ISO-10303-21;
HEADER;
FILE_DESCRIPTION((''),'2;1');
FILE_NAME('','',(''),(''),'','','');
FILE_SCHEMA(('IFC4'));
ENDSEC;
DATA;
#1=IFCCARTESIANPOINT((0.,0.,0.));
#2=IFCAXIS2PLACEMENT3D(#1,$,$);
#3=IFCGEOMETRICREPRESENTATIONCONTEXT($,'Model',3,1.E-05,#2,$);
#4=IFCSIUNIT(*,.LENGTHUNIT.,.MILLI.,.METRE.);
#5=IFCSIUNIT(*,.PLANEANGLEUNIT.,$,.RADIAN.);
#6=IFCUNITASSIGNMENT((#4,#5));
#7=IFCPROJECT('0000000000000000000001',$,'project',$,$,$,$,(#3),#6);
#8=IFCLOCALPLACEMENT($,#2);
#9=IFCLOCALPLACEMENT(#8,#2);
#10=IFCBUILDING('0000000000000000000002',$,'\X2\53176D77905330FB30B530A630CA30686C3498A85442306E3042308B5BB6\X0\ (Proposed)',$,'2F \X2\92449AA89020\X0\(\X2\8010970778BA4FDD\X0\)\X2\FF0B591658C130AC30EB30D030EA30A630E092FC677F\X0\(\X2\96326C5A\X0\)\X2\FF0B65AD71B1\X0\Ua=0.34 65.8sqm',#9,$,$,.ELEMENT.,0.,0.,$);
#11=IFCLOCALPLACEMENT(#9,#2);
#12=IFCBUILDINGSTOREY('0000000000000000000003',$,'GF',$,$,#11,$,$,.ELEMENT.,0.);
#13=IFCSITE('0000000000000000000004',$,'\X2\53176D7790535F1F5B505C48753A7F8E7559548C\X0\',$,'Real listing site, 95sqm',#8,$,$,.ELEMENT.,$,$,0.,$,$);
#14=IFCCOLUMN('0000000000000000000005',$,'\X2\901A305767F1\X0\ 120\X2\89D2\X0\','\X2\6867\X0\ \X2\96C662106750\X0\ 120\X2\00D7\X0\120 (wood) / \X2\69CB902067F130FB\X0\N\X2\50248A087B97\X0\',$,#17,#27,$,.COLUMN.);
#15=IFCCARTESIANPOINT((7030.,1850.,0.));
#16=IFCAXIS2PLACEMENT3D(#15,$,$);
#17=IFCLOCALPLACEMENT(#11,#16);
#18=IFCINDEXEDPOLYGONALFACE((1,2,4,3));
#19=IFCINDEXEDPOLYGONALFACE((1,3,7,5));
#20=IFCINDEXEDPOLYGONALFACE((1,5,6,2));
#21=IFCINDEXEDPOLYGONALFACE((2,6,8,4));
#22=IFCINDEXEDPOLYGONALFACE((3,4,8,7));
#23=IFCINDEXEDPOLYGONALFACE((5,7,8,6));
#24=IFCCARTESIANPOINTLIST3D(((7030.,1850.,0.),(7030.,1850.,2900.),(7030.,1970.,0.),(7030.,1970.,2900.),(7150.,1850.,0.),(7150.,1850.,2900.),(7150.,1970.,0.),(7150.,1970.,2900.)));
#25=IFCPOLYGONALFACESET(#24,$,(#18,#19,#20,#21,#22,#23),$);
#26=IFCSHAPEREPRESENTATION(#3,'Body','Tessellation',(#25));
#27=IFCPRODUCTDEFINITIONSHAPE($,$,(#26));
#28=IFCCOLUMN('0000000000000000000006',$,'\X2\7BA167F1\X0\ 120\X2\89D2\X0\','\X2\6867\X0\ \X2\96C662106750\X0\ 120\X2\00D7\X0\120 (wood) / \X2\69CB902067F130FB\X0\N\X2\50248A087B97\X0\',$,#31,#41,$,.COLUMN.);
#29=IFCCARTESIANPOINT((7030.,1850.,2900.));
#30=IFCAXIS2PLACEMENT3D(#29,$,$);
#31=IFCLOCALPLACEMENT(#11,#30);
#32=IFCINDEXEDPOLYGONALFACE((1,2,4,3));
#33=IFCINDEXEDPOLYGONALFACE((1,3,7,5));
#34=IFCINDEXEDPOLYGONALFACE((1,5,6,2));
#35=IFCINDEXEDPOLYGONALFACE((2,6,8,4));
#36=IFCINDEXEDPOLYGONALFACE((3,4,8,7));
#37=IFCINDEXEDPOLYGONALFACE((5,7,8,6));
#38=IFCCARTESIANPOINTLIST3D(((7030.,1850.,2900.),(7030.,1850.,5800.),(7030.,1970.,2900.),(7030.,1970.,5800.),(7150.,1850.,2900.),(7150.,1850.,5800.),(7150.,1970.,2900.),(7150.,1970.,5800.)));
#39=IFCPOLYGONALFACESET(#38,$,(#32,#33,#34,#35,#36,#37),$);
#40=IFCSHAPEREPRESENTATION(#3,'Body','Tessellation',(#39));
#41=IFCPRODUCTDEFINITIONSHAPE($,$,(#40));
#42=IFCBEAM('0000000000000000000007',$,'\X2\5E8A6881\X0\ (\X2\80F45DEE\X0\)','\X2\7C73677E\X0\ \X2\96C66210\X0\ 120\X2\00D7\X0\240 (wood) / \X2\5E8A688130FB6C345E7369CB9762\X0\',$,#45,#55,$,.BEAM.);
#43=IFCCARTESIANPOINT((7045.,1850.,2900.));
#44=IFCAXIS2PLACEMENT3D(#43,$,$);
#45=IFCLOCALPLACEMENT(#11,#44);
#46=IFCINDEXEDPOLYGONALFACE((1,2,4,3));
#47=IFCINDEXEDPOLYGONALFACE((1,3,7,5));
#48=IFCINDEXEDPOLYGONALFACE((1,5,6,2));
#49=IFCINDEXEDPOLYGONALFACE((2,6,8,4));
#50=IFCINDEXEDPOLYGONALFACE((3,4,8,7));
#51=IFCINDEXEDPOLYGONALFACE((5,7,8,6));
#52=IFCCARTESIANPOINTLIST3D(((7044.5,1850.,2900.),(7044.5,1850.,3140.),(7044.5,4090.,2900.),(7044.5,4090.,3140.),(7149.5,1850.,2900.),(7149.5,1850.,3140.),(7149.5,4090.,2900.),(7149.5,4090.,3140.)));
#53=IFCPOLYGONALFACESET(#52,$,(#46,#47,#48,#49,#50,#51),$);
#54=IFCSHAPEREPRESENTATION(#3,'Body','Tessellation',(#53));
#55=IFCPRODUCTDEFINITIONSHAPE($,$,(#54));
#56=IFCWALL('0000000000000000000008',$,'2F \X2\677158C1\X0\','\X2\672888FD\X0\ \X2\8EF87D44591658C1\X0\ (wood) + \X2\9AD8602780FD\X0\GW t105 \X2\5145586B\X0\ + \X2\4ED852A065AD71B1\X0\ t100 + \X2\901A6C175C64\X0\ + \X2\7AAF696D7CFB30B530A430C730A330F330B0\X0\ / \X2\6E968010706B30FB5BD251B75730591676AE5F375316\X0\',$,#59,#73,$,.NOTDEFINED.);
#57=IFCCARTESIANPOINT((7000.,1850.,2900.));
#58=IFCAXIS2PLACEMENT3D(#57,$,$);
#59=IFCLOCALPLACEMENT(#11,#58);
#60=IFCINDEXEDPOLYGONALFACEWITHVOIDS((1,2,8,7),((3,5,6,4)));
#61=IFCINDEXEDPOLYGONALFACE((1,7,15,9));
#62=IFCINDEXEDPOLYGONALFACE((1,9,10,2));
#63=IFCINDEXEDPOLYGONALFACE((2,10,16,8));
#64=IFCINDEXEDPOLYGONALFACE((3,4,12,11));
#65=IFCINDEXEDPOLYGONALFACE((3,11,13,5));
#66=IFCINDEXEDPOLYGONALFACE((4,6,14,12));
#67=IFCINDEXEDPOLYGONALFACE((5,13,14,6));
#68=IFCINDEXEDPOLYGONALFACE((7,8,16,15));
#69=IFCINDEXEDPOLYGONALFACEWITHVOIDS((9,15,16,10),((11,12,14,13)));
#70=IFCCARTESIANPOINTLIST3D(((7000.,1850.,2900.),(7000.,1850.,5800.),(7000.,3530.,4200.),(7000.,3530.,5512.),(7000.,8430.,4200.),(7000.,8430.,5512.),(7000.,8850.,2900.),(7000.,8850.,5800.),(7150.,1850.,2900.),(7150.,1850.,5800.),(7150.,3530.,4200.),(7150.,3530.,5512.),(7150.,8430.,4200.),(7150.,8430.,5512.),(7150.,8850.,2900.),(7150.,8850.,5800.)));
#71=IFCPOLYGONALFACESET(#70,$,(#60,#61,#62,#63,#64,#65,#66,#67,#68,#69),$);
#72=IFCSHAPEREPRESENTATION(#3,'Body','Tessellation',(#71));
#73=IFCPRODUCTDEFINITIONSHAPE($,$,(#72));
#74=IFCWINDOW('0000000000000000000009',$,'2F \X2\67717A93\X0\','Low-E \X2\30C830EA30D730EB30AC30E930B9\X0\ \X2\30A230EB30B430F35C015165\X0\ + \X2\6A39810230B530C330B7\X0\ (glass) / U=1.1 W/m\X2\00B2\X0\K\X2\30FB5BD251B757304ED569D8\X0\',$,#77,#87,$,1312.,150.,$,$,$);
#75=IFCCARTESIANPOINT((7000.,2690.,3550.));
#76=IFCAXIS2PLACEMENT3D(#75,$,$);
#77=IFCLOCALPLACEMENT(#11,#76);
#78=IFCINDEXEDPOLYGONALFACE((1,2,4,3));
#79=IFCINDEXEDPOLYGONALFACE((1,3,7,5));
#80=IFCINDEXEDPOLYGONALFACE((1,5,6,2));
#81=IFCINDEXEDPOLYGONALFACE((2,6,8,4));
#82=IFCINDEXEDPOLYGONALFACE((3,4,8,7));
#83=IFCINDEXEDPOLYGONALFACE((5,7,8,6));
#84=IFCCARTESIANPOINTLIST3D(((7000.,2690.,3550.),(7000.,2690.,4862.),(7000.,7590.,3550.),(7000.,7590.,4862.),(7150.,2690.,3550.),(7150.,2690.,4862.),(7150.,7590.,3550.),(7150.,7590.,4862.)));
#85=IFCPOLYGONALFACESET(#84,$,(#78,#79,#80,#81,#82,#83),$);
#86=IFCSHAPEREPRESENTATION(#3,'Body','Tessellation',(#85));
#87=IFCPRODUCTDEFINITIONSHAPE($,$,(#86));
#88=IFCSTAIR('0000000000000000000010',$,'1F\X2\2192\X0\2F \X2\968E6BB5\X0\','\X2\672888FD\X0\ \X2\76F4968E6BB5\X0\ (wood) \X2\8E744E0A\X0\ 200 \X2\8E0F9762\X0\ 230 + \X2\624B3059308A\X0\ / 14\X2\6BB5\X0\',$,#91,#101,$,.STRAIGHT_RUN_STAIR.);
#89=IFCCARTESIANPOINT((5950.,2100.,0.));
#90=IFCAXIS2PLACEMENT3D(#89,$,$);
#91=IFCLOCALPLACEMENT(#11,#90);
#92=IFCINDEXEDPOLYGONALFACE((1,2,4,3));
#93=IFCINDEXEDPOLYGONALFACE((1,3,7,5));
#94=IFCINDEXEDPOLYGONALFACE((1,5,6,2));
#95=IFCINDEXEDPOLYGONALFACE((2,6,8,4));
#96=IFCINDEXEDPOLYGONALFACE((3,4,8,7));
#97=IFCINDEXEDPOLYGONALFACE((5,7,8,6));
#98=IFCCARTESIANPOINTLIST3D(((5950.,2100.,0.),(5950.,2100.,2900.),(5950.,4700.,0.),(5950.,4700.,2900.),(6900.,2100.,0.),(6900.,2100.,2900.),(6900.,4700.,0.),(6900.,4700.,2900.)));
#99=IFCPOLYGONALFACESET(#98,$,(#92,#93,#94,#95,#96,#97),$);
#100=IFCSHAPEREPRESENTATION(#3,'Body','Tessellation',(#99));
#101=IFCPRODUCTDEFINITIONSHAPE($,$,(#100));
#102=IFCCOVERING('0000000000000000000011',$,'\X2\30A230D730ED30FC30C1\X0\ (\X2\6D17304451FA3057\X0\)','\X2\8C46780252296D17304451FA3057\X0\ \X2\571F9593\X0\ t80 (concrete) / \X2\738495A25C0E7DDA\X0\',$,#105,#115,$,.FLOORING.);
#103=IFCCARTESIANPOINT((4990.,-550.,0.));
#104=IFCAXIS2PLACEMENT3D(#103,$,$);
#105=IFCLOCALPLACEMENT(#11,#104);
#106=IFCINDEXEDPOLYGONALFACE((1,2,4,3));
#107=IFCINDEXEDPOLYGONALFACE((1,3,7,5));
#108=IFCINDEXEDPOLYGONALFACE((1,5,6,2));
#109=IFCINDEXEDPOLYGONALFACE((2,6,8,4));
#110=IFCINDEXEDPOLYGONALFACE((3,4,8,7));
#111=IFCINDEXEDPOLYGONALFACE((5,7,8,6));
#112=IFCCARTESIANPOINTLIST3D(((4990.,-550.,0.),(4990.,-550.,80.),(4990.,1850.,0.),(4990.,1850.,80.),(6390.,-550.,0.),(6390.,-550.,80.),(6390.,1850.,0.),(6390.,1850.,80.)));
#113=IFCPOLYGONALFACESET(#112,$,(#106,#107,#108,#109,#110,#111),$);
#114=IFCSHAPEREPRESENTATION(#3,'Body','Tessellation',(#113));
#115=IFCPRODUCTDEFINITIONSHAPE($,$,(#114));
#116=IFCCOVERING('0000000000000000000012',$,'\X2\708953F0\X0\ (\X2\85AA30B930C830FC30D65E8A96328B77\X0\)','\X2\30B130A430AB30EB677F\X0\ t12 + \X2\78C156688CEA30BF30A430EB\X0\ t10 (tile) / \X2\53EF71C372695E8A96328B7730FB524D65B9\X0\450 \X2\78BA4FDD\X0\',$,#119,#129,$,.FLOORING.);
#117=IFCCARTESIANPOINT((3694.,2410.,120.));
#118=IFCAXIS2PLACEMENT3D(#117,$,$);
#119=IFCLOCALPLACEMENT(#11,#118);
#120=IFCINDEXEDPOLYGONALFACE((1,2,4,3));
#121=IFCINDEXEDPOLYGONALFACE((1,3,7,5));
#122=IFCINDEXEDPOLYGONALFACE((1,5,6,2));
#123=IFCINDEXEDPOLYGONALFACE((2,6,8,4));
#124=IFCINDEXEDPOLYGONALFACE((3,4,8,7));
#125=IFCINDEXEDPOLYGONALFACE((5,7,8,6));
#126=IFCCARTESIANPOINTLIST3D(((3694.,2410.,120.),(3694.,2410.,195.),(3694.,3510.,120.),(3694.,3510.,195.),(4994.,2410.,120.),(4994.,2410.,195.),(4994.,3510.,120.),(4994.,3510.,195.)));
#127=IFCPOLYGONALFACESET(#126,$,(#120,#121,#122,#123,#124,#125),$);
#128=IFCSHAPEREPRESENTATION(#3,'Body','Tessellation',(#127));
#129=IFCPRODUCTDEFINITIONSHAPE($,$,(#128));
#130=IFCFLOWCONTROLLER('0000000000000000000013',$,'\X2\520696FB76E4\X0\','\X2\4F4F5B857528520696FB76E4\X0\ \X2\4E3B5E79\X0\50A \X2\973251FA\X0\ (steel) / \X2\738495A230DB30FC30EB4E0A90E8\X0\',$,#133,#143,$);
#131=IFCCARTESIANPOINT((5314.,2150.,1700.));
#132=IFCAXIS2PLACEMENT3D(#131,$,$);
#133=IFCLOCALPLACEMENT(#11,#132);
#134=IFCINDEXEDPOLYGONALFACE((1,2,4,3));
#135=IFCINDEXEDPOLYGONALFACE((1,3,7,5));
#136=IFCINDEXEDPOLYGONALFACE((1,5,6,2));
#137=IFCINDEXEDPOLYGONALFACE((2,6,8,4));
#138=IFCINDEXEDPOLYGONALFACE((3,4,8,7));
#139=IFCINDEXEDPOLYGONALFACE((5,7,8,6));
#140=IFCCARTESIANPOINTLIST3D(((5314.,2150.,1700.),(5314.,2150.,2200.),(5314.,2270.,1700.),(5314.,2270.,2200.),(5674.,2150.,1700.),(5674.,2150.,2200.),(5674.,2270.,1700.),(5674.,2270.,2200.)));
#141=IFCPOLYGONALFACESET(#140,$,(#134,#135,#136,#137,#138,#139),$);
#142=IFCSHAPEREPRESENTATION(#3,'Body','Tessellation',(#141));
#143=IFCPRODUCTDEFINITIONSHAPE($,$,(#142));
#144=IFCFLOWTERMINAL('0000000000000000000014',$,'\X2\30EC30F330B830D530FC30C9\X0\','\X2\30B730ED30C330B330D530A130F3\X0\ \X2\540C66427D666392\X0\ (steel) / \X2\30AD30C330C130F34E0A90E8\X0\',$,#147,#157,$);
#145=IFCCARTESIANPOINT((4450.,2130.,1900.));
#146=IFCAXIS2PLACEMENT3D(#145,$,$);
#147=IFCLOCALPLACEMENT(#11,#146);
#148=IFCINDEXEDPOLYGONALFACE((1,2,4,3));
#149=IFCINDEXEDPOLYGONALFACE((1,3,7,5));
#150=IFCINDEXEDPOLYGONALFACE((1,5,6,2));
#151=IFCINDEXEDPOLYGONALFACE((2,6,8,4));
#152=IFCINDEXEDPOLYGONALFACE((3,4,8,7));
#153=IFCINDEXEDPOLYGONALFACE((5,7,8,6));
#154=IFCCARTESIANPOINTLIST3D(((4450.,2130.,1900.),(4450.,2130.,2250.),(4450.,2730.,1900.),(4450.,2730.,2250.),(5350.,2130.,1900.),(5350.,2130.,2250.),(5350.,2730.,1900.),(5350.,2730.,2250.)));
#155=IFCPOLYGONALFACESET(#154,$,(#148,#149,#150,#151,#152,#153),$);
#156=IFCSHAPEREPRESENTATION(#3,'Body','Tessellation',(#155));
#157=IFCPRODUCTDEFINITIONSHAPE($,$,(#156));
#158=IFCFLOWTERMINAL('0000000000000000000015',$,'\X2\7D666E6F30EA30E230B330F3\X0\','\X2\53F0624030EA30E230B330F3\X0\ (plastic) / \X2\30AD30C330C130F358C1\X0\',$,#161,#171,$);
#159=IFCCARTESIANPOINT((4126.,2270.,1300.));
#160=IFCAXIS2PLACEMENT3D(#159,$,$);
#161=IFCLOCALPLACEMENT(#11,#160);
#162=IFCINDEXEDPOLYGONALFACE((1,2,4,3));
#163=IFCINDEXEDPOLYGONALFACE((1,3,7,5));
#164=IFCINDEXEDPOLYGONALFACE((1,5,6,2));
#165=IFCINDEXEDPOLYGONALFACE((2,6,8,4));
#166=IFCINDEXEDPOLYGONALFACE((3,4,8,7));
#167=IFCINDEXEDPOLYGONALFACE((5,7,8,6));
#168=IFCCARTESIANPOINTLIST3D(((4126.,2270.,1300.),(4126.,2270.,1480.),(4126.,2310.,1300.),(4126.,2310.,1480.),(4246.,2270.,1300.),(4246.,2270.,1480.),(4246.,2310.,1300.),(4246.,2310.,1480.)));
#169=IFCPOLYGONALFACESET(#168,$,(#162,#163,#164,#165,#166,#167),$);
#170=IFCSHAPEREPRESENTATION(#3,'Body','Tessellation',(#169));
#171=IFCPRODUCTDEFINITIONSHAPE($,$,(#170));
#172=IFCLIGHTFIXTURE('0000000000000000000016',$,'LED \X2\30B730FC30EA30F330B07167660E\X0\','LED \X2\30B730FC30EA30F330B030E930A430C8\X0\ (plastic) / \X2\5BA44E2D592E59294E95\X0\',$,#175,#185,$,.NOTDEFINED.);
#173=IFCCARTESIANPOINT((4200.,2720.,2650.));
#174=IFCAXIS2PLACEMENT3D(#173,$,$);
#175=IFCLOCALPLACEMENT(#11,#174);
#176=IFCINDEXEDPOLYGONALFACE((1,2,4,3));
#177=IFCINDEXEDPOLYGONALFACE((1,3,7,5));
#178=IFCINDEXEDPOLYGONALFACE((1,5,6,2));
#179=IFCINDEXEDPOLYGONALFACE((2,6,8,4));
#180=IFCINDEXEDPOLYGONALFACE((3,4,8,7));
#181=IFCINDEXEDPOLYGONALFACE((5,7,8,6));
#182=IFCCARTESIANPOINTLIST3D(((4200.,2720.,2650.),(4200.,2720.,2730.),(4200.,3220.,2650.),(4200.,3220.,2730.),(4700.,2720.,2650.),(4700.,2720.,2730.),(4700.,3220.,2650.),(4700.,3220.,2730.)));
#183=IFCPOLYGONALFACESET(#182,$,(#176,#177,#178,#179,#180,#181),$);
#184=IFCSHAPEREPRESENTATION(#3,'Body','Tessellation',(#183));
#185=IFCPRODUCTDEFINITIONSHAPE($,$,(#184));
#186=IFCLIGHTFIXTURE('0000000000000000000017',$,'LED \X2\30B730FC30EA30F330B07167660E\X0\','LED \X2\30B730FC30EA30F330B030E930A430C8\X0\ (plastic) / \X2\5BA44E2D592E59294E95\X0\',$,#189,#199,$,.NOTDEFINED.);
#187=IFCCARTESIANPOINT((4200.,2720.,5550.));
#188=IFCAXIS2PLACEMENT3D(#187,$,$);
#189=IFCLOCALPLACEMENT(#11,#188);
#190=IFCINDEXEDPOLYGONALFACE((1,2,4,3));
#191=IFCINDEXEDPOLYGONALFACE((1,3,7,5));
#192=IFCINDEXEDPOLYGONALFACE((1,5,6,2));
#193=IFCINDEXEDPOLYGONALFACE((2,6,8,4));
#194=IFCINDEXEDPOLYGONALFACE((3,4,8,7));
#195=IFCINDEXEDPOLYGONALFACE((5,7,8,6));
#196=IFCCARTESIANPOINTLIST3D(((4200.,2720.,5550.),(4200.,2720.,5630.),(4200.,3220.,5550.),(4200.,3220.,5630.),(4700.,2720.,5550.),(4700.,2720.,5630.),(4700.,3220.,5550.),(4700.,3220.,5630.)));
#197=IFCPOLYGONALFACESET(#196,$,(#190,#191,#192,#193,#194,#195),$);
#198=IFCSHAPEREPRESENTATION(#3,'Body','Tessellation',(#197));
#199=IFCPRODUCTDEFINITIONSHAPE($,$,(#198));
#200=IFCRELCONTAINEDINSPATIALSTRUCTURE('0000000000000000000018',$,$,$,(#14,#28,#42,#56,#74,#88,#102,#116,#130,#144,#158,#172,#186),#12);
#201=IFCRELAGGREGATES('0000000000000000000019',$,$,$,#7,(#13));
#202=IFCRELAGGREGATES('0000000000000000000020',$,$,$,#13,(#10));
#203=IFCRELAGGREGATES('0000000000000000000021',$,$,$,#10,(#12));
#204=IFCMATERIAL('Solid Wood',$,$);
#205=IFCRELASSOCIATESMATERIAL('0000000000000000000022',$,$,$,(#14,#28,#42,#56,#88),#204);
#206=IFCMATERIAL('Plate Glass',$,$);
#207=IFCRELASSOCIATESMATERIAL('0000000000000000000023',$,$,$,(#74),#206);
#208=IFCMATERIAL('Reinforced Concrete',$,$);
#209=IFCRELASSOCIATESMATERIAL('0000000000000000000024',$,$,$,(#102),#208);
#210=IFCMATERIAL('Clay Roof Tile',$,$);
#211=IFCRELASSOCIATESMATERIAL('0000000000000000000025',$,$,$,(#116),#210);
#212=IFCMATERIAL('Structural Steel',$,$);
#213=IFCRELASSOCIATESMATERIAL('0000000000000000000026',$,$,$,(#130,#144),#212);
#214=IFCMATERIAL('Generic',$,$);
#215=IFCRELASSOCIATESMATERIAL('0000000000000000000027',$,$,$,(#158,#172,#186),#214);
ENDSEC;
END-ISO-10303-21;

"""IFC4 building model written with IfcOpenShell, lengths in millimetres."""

from ifc_helpers import new_model, si_unit, frame, frame_2d, origin, place, context, project, spatial, rectangle, extrude, material, element, fill, save


model = new_model("IFC4")

# Units and contexts
model_context = context("Model", 3, precision=1e-05, world=origin())
ifc_project = project(units=[si_unit("LENGTHUNIT", "METRE", prefix="MILLI"), si_unit("PLANEANGLEUNIT", "RADIAN")], contexts=[model_context])

# Site, building, storey
site_placement = place(None, origin())
site = spatial("IfcSite", under=ifc_project, at=site_placement, Name="北海道弟子屈町美留和", ObjectType="Real listing site, 95sqm", CompositionType="ELEMENT", RefElevation=0.0)
building_placement = place(site_placement, origin())
building = spatial("IfcBuilding", under=site, at=building_placement, Name="北海道・サウナと水風呂のある家 (Proposed)", ObjectType="2F 鉄骨造(耐震確保)＋外壁ガルバリウム鋼板(防汚)＋断熱Ua=0.34 65.8sqm", CompositionType="ELEMENT", ElevationOfRefHeight=0.0, ElevationOfTerrain=0.0)
storey_placement = place(building_placement, origin())
storey = spatial("IfcBuildingStorey", under=building, at=storey_placement, Name="GF", CompositionType="ELEMENT", Elevation=0.0)

# Columns
ifc_material_1 = material(Name="Solid Wood")
column_1_placement = place(storey_placement, frame((7030.0, 1850.0, 0.0)))
element("IfcColumn", 1, at=column_1_placement, inside=storey, material=ifc_material_1, Name="通し柱 120角", Description="桧 集成材 120×120 (wood) / 構造柱・N値計算", PredefinedType="COLUMN", context=model_context, shape_type="SweptSolid", body=[
    extrude(rectangle(XDim=120.0, YDim=120.0, at=frame_2d((60.0, 60.0))), frame((7030.0, 1850.0, 0.0)), (0.0, 0.0, 1.0), 2900.0),
])
column_2_placement = place(storey_placement, frame((7030.0, 1850.0, 2900.0)))
element("IfcColumn", 2, at=column_2_placement, inside=storey, material=ifc_material_1, Name="管柱 120角", Description="桧 集成材 120×120 (wood) / 構造柱・N値計算", PredefinedType="COLUMN", context=model_context, shape_type="SweptSolid", body=[
    extrude(rectangle(XDim=120.0, YDim=120.0, at=frame_2d((60.0, 60.0))), frame((7030.0, 1850.0, 2900.0)), (0.0, 0.0, 1.0), 2900.0),
])

# Beam
beam_1_placement = place(storey_placement, frame((7045.0, 1850.0, 2900.0)))
element("IfcBeam", 3, at=beam_1_placement, inside=storey, material=ifc_material_1, Name="床梁 (胴差)", Description="米松 集成 120×240 (wood) / 床梁・水平構面", PredefinedType="BEAM", context=model_context, shape_type="SweptSolid", body=[
    extrude(rectangle(XDim=105.0, YDim=2240.0, at=frame_2d((52.0, 1120.0))), frame((7045.0, 1850.0, 2900.0)), (0.0, 0.0, 1.0), 240.0),
])

# Shared definitions
ifc_material_2 = material(Name="Plate Glass")

# Wall, opening, window
wall_1_placement = place(storey_placement, frame((7000.0, 1850.0, 2900.0)))
wall_1 = element("IfcWall", 4, at=wall_1_placement, inside=storey, material=ifc_material_1, Name="2F 東壁", Description="木製 軸組外壁 (wood) + 高性能GW t105 充填 + 付加断熱 t100 + 通気層 + 窯業系サイディング / 準耐火・寒冷地外皮強化", PredefinedType="NOTDEFINED", context=model_context, shape_type="SweptSolid", body=[
    extrude(rectangle(XDim=150.0, YDim=7000.0, at=frame_2d((75.0, 3500.0))), frame((7000.0, 1850.0, 2900.0)), (0.0, 0.0, 1.0), 2900.0),
])
opening_1_placement = place(storey_placement, frame((7000.0, 2690.0, 3550.0)))
opening_1 = element("IfcOpeningElement", 5, at=opening_1_placement, cuts=wall_1, PredefinedType="NOTDEFINED", context=model_context, shape_type="SweptSolid", body=[
    extrude(rectangle(XDim=150.0, YDim=4900.0, at=frame_2d((75.0, 2450.0))), frame((7000.0, 2690.0, 3550.0)), (0.0, 0.0, 1.0), 1312.0),
])
window_1_placement = place(storey_placement, frame((7000.0, 2690.0, 3550.0)))
window_1 = element("IfcWindow", 6, at=window_1_placement, inside=storey, material=ifc_material_2, Name="2F 東窓", Description="Low-E トリプルガラス アルゴン封入 + 樹脂サッシ (glass) / U=1.1 W/m²K・寒冷地仕様", OverallHeight=1312.0, OverallWidth=150.0, context=model_context, shape_type="SweptSolid", body=[
    extrude(rectangle(XDim=150.0, YDim=4900.0, at=frame_2d((75.0, 2450.0))), frame((7000.0, 2690.0, 3550.0)), (0.0, 0.0, 1.0), 1312.0),
])
fill(opening_1, window_1)

# Stair
stair_placement = place(storey_placement, frame((5950.0, 2100.0, 0.0)))
element("IfcStair", 7, at=stair_placement, inside=storey, material=ifc_material_1, Name="1F→2F 階段", Description="木製 直階段 (wood) 蹴上 200 踏面 230 + 手すり / 14段", PredefinedType="STRAIGHT_RUN_STAIR", context=model_context, shape_type="SweptSolid", body=[
    extrude(rectangle(XDim=950.0, YDim=2600.0, at=frame_2d((475.0, 1300.0))), frame((5950.0, 2100.0, 0.0)), (0.0, 0.0, 1.0), 2900.0),
])

# Coverings
ifc_material_3 = material(Name="Reinforced Concrete")
covering_1_placement = place(storey_placement, frame((4990.0, -550.0, 0.0)))
element("IfcCovering", 8, at=covering_1_placement, inside=storey, material=ifc_material_3, Name="アプローチ (洗い出し)", Description="豆砂利洗い出し 土間 t80 (concrete) / 玄関導線", PredefinedType="FLOORING", context=model_context, shape_type="SweptSolid", body=[
    extrude(rectangle(XDim=1400.0, YDim=2400.0, at=frame_2d((700.0, 1200.0))), frame((4990.0, -550.0, 0.0)), (0.0, 0.0, 1.0), 80.0),
])
ifc_material_4 = material(Name="Clay Roof Tile")
covering_2_placement = place(storey_placement, frame((3694.0, 2410.0, 120.0)))
element("IfcCovering", 9, at=covering_2_placement, inside=storey, material=ifc_material_4, Name="炉台 (薪ストーブ床防護)", Description="ケイカル板 t12 + 磁器質タイル t10 (tile) / 可燃物床防護・前方450 確保", PredefinedType="FLOORING", context=model_context, shape_type="SweptSolid", body=[
    extrude(rectangle(XDim=1300.0, YDim=1100.0, at=frame_2d((650.0, 550.0))), frame((3694.0, 2410.0, 120.0)), (0.0, 0.0, 1.0), 75.0),
])

# Flow controller
ifc_material_5 = material(Name="Structural Steel")
flow_controller_placement = place(storey_placement, frame((5314.0, 2150.0, 1700.0)))
element("IfcFlowController", 10, at=flow_controller_placement, inside=storey, material=ifc_material_5, Name="分電盤", Description="住宅用分電盤 主幹50A 露出 (steel) / 玄関ホール上部", context=model_context, shape_type="SweptSolid", body=[
    extrude(rectangle(XDim=360.0, YDim=120.0, at=frame_2d((180.0, 60.0))), frame((5314.0, 2150.0, 1700.0)), (0.0, 0.0, 1.0), 500.0),
])

# Flow terminals
flow_terminal_1_placement = place(storey_placement, frame((4450.0, 2130.0, 1900.0)))
element("IfcFlowTerminal", 11, at=flow_terminal_1_placement, inside=storey, material=ifc_material_5, Name="レンジフード", Description="シロッコファン 同時給排 (steel) / キッチン上部", context=model_context, shape_type="SweptSolid", body=[
    extrude(rectangle(XDim=900.0, YDim=600.0, at=frame_2d((450.0, 300.0))), frame((4450.0, 2130.0, 1900.0)), (0.0, 0.0, 1.0), 350.0),
])
ifc_material_6 = material(Name="Generic")
flow_terminal_2_placement = place(storey_placement, frame((4126.0, 2270.0, 1300.0)))
element("IfcFlowTerminal", 12, at=flow_terminal_2_placement, inside=storey, material=ifc_material_6, Name="給湯リモコン", Description="台所リモコン (plastic) / キッチン壁", context=model_context, shape_type="SweptSolid", body=[
    extrude(rectangle(XDim=120.0, YDim=40.0, at=frame_2d((60.0, 20.0))), frame((4126.0, 2270.0, 1300.0)), (0.0, 0.0, 1.0), 180.0),
])

# Light fixtures
light_fixture_1_placement = place(storey_placement, frame((4200.0, 2720.0, 2650.0)))
element("IfcLightFixture", 13, at=light_fixture_1_placement, inside=storey, material=ifc_material_6, Name="LED シーリング照明", Description="LED シーリングライト (plastic) / 室中央天井", PredefinedType="NOTDEFINED", context=model_context, shape_type="SweptSolid", body=[
    extrude(rectangle(XDim=500.0, YDim=500.0, at=frame_2d((250.0, 250.0))), frame((4200.0, 2720.0, 2650.0)), (0.0, 0.0, 1.0), 80.0),
])
light_fixture_2_placement = place(storey_placement, frame((4200.0, 2720.0, 5550.0)))
element("IfcLightFixture", 14, at=light_fixture_2_placement, inside=storey, material=ifc_material_6, Name="LED シーリング照明", Description="LED シーリングライト (plastic) / 室中央天井", PredefinedType="NOTDEFINED", context=model_context, shape_type="SweptSolid", body=[
    extrude(rectangle(XDim=500.0, YDim=500.0, at=frame_2d((250.0, 250.0))), frame((4200.0, 2720.0, 5550.0)), (0.0, 0.0, 1.0), 80.0),
])

save(model, "model.ifc")
